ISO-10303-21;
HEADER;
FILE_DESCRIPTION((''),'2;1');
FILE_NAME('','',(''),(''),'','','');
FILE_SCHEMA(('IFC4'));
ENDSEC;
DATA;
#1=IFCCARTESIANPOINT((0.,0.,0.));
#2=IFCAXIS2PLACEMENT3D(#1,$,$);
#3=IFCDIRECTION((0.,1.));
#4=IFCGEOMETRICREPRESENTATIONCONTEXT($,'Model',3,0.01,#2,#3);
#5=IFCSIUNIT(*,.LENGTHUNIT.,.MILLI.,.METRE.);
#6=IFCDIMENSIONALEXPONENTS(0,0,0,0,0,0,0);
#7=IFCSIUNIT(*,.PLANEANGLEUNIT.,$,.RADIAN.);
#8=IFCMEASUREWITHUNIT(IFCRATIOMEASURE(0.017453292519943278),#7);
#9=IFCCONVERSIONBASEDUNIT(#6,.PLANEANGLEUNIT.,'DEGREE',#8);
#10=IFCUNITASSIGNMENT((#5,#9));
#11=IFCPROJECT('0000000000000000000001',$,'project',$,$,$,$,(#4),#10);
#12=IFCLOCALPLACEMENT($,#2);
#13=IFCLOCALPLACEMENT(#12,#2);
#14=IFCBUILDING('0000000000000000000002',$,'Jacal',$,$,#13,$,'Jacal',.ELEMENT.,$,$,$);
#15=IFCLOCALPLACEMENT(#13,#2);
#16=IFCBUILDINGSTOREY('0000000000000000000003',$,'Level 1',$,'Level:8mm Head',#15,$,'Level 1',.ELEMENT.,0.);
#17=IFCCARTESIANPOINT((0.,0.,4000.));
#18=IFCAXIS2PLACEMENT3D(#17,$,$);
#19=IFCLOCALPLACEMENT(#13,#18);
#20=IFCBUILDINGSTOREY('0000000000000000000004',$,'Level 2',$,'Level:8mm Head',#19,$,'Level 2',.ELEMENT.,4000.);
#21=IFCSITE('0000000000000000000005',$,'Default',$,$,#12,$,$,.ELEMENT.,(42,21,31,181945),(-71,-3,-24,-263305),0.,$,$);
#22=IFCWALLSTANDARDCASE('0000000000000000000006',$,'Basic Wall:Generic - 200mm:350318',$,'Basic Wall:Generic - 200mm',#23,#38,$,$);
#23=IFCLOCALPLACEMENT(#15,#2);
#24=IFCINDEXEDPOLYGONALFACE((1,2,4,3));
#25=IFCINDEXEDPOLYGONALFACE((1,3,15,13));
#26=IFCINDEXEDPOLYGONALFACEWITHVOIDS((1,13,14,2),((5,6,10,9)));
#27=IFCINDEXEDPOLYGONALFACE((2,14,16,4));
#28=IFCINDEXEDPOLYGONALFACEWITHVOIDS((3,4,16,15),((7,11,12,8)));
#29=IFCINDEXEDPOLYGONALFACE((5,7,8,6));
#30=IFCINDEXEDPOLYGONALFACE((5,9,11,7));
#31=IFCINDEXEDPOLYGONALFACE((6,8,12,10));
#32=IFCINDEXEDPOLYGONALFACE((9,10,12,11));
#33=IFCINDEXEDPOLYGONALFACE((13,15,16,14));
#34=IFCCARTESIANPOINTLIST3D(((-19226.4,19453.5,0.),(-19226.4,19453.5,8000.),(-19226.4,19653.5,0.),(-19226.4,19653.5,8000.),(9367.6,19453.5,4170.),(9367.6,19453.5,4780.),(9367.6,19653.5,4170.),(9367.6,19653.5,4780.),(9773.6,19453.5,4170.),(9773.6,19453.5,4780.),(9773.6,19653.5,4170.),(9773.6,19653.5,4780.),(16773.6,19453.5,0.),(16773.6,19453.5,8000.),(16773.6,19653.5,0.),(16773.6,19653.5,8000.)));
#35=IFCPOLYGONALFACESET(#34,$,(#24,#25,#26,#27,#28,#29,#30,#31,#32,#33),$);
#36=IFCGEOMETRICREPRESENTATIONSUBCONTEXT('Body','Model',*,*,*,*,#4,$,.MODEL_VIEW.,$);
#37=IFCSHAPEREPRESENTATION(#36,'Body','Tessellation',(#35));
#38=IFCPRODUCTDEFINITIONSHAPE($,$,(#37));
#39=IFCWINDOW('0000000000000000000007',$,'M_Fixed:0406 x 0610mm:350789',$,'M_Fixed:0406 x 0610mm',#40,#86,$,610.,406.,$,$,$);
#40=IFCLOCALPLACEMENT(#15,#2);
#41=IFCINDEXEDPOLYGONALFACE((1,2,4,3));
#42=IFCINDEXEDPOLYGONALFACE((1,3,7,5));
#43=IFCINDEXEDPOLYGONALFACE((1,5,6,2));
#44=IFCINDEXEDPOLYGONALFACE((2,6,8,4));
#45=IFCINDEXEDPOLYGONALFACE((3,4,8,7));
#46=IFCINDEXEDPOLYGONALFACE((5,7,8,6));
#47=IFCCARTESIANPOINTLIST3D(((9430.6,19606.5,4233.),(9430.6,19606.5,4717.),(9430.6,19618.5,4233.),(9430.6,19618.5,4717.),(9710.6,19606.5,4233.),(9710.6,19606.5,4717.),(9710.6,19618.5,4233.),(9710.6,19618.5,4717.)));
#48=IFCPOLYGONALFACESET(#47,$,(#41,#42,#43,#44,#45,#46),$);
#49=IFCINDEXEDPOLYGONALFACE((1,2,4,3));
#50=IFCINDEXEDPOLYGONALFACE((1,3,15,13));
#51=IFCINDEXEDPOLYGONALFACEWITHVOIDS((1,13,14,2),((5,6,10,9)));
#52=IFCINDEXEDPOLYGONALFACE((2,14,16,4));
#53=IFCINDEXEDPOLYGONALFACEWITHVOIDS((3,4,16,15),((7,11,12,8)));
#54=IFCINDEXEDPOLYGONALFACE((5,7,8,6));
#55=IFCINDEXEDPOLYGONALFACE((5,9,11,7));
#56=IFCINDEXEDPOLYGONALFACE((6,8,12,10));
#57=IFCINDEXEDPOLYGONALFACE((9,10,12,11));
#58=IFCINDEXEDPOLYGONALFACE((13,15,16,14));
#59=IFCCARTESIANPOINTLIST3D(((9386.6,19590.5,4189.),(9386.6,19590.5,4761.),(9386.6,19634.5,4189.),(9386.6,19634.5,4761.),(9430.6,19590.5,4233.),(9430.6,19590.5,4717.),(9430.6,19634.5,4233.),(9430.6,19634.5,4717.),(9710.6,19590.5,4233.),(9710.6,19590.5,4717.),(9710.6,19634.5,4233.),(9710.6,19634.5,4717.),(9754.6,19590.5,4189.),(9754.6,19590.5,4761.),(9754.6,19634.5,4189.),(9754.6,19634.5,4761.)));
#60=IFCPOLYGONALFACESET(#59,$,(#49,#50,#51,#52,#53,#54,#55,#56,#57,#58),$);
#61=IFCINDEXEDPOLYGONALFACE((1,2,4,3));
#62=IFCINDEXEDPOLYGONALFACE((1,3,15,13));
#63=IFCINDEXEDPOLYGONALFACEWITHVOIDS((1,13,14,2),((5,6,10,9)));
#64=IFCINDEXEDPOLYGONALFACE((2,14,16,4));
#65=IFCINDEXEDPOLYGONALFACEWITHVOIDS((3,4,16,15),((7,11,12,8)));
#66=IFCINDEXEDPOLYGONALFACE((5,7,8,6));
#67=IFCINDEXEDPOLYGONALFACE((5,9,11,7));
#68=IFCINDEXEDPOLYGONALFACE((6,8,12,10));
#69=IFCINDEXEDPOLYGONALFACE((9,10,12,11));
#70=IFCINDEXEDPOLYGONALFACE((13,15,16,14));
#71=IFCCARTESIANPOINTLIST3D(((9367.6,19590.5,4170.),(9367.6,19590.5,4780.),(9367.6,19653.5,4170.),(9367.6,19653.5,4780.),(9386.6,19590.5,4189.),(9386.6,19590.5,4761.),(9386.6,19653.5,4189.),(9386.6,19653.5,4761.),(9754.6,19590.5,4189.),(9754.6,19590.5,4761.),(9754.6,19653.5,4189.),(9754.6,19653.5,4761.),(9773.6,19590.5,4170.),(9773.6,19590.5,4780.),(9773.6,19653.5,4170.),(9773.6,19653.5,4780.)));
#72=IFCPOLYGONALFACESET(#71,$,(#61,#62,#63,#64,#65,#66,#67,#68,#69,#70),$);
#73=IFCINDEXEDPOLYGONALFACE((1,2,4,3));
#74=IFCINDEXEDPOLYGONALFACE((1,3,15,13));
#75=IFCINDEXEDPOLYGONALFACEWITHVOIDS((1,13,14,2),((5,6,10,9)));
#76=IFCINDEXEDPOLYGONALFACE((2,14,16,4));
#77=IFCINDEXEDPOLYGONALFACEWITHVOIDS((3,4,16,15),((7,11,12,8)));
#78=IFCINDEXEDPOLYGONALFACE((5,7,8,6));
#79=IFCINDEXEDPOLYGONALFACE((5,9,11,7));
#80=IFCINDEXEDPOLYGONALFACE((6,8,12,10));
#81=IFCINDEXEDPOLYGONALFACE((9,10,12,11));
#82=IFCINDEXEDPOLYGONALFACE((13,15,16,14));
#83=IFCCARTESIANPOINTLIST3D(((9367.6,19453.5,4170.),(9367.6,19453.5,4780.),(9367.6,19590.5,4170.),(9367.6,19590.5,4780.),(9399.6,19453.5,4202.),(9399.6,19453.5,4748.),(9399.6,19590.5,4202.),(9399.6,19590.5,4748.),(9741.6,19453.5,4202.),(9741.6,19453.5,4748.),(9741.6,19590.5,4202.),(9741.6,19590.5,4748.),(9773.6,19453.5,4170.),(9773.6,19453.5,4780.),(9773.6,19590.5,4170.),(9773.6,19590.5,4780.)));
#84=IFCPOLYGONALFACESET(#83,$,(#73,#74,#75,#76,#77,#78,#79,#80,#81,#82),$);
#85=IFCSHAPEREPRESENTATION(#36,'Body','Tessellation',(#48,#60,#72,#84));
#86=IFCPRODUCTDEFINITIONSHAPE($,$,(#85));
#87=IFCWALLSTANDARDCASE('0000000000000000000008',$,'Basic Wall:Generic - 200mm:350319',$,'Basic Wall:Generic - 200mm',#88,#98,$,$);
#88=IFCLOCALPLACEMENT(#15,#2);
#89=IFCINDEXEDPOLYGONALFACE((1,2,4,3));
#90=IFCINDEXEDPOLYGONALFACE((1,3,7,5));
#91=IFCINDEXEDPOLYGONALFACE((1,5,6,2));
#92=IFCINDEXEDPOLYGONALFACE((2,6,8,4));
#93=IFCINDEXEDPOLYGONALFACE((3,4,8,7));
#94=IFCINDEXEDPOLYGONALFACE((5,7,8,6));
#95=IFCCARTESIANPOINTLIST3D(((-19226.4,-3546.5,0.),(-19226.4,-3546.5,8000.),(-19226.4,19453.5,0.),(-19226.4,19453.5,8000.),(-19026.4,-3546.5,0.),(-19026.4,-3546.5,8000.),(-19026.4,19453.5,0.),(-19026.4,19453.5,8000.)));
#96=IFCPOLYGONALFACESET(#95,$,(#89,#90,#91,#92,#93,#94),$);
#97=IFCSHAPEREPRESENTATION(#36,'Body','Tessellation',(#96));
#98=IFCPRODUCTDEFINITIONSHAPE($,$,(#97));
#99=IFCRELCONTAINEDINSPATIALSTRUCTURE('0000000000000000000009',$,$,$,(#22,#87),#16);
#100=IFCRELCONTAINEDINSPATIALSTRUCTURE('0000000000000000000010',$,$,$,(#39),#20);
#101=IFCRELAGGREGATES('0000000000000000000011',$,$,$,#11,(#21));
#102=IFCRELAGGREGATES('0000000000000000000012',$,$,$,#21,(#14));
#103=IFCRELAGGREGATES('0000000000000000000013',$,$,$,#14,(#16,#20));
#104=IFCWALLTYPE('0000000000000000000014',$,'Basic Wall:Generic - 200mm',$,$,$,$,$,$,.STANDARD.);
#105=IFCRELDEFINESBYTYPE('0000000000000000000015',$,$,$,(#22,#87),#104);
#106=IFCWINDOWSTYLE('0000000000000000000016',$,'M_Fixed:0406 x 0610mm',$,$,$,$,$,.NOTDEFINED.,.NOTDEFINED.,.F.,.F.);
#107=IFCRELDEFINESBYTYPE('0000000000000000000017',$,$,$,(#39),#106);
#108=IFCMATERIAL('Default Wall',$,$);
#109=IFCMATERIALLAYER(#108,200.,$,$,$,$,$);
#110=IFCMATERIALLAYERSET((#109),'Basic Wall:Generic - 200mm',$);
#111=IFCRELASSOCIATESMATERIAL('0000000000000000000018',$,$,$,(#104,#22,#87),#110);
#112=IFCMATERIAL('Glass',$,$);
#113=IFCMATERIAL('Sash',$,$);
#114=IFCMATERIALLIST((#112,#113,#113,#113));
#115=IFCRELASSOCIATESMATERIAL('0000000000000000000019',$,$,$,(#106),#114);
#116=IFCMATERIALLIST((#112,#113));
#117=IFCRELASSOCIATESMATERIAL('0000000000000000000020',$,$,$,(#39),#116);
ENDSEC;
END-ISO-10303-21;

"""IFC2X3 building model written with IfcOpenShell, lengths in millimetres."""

from ifc_helpers import new_model, entity, si_unit, converted_unit, direction, frame, frame_2d, origin, place, context, subcontext, project, spatial, polyline, rectangle, outline, extrude, source, transform, mapped, material, material_list, layer, layer_set, layer_usage, type_object, type_shapes, element, fill, save


model = new_model("IFC2X3")

# Units and contexts
model_context = context("Model", 3, precision=0.01, world=origin(), true_north=direction((0.0, 1.0)))
body_context = subcontext(model_context, "Body", "Model", "MODEL_VIEW")
ifc_project = project(units=[si_unit("LENGTHUNIT", "METRE", prefix="MILLI"), converted_unit("PLANEANGLEUNIT", "DEGREE", entity("IfcRatioMeasure", 0.017453292519943278), si_unit("PLANEANGLEUNIT", "RADIAN"), dimensions=[0, 0, 0, 0, 0, 0, 0])], contexts=[model_context])

# Site, building, storey
site_placement = place(None, origin())
site = spatial("IfcSite", under=ifc_project, at=site_placement, Name="Default", CompositionType="ELEMENT", RefLatitude=(42, 21, 31, 181945), RefLongitude=(-71, -3, -24, -263305), RefElevation=0.0)
building_placement = place(site_placement, origin())
building = spatial("IfcBuilding", under=site, at=building_placement, Name="Jacal", LongName="Jacal", CompositionType="ELEMENT")
storey_1_placement = place(building_placement, origin())
storey_1 = spatial("IfcBuildingStorey", under=building, at=storey_1_placement, Name="Level 1", ObjectType="Level:8mm Head", LongName="Level 1", CompositionType="ELEMENT", Elevation=0.0)

# Wall, opening
ifc_material_1 = material(Name="Default Wall")
ifc_layer = layer(ifc_material_1, 200.0)
ifc_layer_set = layer_set([ifc_layer], Name="Basic Wall:Generic - 200mm")
ifc_layer_usage_1 = layer_usage(ifc_layer_set, "AXIS2", "NEGATIVE", 100.0)
wall_type = type_object("IfcWallType", Name="Basic Wall:Generic - 200mm", PredefinedType="STANDARD", material=ifc_layer_set)
wall_1_placement = place(storey_1_placement, frame((-19226.4, 19553.5, 0.0)))
wall_1 = element("IfcWallStandardCase", 1, at=wall_1_placement, inside=storey_1, type_object=wall_type, material=ifc_layer_usage_1, Name="Basic Wall:Generic - 200mm:350318", ObjectType="Basic Wall:Generic - 200mm", context=body_context, shape_type="SweptSolid", body=[
    extrude(rectangle(XDim=36000.0, YDim=200.0, at=frame_2d((18000.0, 0.0), x_axis=(-1.0, 0.0))), origin(), (0.0, 0.0, 1.0), 8000.0),
])
opening_1_placement = place(wall_1_placement, frame((28594.0, -100.0, 4170.0)))
opening_1 = element("IfcOpeningElement", 2, at=opening_1_placement, cuts=wall_1, ObjectType="Opening", context=body_context, shape_type="SweptSolid", body=[
    extrude(rectangle(XDim=610.0, YDim=406.0, at=frame_2d((305.0, 203.0), x_axis=(1.0, 0.0))), frame((0.0, 0.0, 0.0), z_axis=(0.0, 1.0, 0.0), x_axis=(0.0, 0.0, 1.0)), (0.0, 0.0, 1.0), 200.0),
])

# Shared definitions
storey_2_placement = place(building_placement, frame((0.0, 0.0, 4000.0)))
storey_2 = spatial("IfcBuildingStorey", under=building, at=storey_2_placement, Name="Level 2", ObjectType="Level:8mm Head", LongName="Level 2", CompositionType="ELEMENT", Elevation=4000.0)

# Window
ifc_material_2 = material(Name="Glass")
ifc_material_3 = material(Name="Sash")
ifc_material_list_1 = material_list([ifc_material_2, ifc_material_3])
ifc_material_list_2 = material_list([ifc_material_2, ifc_material_3, ifc_material_3, ifc_material_3])
window_style = type_object("IfcWindowStyle", Name="M_Fixed:0406 x 0610mm", ConstructionType="NOTDEFINED", OperationType="NOTDEFINED", ParameterTakesPrecedence=False, Sizeable=False, material=ifc_material_list_2)
shared_shape_1 = source(origin(), body_context, "Body", "SweptSolid", [
    extrude(rectangle(XDim=12.0, YDim=280.0, at=frame_2d((0.0, 0.0), x_axis=(1.0, 0.0))), frame((203.0, 159.0, 63.0), z_axis=(0.0, 0.0, 1.0), x_axis=(0.0, -1.0, 0.0)), (0.0, 0.0, 1.0), 484.0),
    extrude(outline(polyline([(-184.0, -286.0), (184.0, -286.0), (184.0, 286.0), (-184.0, 286.0), (-184.0, -286.0)]), holes=[polyline([(-140.0, -242.0), (-140.0, 242.0), (140.0, 242.0), (140.0, -242.0), (-140.0, -242.0)])]), frame((203.0, 137.0, 305.0), z_axis=(0.0, 1.0, 0.0), x_axis=(1.0, 0.0, 0.0)), (0.0, 0.0, 1.0), 44.0),
    extrude(outline(polyline([(-203.0, -305.0), (203.0, -305.0), (203.0, 305.0), (-203.0, 305.0), (-203.0, -305.0)]), holes=[polyline([(-184.0, -286.0), (-184.0, 286.0), (184.0, 286.0), (184.0, -286.0), (-184.0, -286.0)])]), frame((203.0, 137.0, 305.0), z_axis=(0.0, 1.0, 0.0), x_axis=(1.0, 0.0, 0.0)), (0.0, 0.0, 1.0), 63.0),
    extrude(outline(polyline([(-203.0, -305.0), (203.0, -305.0), (203.0, 305.0), (-203.0, 305.0), (-203.0, -305.0)]), holes=[polyline([(-171.0, -273.0), (-171.0, 273.0), (171.0, 273.0), (171.0, -273.0), (-171.0, -273.0)])]), frame((203.0, 0.0, 305.0), z_axis=(0.0, 1.0, 0.0), x_axis=(1.0, 0.0, 0.0)), (0.0, 0.0, 1.0), 137.0),
])
type_shapes(window_style, [shared_shape_1])
window_1_placement = place(opening_1_placement, origin())
window_1 = element("IfcWindow", 3, at=window_1_placement, inside=storey_2, type_object=window_style, material=ifc_material_list_1, Name="M_Fixed:0406 x 0610mm:350789", ObjectType="M_Fixed:0406 x 0610mm", OverallHeight=610.0, OverallWidth=406.0, context=body_context, shape_type="MappedRepresentation", body=[
    mapped(shared_shape_1, transform((0.0, 0.0, 0.0), scale=1.0)),
])
fill(opening_1, window_1)

# Wall
ifc_layer_usage_2 = layer_usage(ifc_layer_set, "AXIS2", "NEGATIVE", 100.0)
wall_2_placement = place(storey_1_placement, frame((-19126.4, -3546.5, 0.0), z_axis=(0.0, 0.0, 1.0), x_axis=(0.0, 1.0, 0.0)))
element("IfcWallStandardCase", 4, at=wall_2_placement, inside=storey_1, type_object=wall_type, material=ifc_layer_usage_2, Name="Basic Wall:Generic - 200mm:350319", ObjectType="Basic Wall:Generic - 200mm", context=body_context, shape_type="SweptSolid", body=[
    extrude(rectangle(XDim=23000.0, YDim=200.0, at=frame_2d((11500.0, 0.0), x_axis=(-1.0, 0.0))), origin(), (0.0, 0.0, 1.0), 8000.0),
])

save(model, "model.ifc")
